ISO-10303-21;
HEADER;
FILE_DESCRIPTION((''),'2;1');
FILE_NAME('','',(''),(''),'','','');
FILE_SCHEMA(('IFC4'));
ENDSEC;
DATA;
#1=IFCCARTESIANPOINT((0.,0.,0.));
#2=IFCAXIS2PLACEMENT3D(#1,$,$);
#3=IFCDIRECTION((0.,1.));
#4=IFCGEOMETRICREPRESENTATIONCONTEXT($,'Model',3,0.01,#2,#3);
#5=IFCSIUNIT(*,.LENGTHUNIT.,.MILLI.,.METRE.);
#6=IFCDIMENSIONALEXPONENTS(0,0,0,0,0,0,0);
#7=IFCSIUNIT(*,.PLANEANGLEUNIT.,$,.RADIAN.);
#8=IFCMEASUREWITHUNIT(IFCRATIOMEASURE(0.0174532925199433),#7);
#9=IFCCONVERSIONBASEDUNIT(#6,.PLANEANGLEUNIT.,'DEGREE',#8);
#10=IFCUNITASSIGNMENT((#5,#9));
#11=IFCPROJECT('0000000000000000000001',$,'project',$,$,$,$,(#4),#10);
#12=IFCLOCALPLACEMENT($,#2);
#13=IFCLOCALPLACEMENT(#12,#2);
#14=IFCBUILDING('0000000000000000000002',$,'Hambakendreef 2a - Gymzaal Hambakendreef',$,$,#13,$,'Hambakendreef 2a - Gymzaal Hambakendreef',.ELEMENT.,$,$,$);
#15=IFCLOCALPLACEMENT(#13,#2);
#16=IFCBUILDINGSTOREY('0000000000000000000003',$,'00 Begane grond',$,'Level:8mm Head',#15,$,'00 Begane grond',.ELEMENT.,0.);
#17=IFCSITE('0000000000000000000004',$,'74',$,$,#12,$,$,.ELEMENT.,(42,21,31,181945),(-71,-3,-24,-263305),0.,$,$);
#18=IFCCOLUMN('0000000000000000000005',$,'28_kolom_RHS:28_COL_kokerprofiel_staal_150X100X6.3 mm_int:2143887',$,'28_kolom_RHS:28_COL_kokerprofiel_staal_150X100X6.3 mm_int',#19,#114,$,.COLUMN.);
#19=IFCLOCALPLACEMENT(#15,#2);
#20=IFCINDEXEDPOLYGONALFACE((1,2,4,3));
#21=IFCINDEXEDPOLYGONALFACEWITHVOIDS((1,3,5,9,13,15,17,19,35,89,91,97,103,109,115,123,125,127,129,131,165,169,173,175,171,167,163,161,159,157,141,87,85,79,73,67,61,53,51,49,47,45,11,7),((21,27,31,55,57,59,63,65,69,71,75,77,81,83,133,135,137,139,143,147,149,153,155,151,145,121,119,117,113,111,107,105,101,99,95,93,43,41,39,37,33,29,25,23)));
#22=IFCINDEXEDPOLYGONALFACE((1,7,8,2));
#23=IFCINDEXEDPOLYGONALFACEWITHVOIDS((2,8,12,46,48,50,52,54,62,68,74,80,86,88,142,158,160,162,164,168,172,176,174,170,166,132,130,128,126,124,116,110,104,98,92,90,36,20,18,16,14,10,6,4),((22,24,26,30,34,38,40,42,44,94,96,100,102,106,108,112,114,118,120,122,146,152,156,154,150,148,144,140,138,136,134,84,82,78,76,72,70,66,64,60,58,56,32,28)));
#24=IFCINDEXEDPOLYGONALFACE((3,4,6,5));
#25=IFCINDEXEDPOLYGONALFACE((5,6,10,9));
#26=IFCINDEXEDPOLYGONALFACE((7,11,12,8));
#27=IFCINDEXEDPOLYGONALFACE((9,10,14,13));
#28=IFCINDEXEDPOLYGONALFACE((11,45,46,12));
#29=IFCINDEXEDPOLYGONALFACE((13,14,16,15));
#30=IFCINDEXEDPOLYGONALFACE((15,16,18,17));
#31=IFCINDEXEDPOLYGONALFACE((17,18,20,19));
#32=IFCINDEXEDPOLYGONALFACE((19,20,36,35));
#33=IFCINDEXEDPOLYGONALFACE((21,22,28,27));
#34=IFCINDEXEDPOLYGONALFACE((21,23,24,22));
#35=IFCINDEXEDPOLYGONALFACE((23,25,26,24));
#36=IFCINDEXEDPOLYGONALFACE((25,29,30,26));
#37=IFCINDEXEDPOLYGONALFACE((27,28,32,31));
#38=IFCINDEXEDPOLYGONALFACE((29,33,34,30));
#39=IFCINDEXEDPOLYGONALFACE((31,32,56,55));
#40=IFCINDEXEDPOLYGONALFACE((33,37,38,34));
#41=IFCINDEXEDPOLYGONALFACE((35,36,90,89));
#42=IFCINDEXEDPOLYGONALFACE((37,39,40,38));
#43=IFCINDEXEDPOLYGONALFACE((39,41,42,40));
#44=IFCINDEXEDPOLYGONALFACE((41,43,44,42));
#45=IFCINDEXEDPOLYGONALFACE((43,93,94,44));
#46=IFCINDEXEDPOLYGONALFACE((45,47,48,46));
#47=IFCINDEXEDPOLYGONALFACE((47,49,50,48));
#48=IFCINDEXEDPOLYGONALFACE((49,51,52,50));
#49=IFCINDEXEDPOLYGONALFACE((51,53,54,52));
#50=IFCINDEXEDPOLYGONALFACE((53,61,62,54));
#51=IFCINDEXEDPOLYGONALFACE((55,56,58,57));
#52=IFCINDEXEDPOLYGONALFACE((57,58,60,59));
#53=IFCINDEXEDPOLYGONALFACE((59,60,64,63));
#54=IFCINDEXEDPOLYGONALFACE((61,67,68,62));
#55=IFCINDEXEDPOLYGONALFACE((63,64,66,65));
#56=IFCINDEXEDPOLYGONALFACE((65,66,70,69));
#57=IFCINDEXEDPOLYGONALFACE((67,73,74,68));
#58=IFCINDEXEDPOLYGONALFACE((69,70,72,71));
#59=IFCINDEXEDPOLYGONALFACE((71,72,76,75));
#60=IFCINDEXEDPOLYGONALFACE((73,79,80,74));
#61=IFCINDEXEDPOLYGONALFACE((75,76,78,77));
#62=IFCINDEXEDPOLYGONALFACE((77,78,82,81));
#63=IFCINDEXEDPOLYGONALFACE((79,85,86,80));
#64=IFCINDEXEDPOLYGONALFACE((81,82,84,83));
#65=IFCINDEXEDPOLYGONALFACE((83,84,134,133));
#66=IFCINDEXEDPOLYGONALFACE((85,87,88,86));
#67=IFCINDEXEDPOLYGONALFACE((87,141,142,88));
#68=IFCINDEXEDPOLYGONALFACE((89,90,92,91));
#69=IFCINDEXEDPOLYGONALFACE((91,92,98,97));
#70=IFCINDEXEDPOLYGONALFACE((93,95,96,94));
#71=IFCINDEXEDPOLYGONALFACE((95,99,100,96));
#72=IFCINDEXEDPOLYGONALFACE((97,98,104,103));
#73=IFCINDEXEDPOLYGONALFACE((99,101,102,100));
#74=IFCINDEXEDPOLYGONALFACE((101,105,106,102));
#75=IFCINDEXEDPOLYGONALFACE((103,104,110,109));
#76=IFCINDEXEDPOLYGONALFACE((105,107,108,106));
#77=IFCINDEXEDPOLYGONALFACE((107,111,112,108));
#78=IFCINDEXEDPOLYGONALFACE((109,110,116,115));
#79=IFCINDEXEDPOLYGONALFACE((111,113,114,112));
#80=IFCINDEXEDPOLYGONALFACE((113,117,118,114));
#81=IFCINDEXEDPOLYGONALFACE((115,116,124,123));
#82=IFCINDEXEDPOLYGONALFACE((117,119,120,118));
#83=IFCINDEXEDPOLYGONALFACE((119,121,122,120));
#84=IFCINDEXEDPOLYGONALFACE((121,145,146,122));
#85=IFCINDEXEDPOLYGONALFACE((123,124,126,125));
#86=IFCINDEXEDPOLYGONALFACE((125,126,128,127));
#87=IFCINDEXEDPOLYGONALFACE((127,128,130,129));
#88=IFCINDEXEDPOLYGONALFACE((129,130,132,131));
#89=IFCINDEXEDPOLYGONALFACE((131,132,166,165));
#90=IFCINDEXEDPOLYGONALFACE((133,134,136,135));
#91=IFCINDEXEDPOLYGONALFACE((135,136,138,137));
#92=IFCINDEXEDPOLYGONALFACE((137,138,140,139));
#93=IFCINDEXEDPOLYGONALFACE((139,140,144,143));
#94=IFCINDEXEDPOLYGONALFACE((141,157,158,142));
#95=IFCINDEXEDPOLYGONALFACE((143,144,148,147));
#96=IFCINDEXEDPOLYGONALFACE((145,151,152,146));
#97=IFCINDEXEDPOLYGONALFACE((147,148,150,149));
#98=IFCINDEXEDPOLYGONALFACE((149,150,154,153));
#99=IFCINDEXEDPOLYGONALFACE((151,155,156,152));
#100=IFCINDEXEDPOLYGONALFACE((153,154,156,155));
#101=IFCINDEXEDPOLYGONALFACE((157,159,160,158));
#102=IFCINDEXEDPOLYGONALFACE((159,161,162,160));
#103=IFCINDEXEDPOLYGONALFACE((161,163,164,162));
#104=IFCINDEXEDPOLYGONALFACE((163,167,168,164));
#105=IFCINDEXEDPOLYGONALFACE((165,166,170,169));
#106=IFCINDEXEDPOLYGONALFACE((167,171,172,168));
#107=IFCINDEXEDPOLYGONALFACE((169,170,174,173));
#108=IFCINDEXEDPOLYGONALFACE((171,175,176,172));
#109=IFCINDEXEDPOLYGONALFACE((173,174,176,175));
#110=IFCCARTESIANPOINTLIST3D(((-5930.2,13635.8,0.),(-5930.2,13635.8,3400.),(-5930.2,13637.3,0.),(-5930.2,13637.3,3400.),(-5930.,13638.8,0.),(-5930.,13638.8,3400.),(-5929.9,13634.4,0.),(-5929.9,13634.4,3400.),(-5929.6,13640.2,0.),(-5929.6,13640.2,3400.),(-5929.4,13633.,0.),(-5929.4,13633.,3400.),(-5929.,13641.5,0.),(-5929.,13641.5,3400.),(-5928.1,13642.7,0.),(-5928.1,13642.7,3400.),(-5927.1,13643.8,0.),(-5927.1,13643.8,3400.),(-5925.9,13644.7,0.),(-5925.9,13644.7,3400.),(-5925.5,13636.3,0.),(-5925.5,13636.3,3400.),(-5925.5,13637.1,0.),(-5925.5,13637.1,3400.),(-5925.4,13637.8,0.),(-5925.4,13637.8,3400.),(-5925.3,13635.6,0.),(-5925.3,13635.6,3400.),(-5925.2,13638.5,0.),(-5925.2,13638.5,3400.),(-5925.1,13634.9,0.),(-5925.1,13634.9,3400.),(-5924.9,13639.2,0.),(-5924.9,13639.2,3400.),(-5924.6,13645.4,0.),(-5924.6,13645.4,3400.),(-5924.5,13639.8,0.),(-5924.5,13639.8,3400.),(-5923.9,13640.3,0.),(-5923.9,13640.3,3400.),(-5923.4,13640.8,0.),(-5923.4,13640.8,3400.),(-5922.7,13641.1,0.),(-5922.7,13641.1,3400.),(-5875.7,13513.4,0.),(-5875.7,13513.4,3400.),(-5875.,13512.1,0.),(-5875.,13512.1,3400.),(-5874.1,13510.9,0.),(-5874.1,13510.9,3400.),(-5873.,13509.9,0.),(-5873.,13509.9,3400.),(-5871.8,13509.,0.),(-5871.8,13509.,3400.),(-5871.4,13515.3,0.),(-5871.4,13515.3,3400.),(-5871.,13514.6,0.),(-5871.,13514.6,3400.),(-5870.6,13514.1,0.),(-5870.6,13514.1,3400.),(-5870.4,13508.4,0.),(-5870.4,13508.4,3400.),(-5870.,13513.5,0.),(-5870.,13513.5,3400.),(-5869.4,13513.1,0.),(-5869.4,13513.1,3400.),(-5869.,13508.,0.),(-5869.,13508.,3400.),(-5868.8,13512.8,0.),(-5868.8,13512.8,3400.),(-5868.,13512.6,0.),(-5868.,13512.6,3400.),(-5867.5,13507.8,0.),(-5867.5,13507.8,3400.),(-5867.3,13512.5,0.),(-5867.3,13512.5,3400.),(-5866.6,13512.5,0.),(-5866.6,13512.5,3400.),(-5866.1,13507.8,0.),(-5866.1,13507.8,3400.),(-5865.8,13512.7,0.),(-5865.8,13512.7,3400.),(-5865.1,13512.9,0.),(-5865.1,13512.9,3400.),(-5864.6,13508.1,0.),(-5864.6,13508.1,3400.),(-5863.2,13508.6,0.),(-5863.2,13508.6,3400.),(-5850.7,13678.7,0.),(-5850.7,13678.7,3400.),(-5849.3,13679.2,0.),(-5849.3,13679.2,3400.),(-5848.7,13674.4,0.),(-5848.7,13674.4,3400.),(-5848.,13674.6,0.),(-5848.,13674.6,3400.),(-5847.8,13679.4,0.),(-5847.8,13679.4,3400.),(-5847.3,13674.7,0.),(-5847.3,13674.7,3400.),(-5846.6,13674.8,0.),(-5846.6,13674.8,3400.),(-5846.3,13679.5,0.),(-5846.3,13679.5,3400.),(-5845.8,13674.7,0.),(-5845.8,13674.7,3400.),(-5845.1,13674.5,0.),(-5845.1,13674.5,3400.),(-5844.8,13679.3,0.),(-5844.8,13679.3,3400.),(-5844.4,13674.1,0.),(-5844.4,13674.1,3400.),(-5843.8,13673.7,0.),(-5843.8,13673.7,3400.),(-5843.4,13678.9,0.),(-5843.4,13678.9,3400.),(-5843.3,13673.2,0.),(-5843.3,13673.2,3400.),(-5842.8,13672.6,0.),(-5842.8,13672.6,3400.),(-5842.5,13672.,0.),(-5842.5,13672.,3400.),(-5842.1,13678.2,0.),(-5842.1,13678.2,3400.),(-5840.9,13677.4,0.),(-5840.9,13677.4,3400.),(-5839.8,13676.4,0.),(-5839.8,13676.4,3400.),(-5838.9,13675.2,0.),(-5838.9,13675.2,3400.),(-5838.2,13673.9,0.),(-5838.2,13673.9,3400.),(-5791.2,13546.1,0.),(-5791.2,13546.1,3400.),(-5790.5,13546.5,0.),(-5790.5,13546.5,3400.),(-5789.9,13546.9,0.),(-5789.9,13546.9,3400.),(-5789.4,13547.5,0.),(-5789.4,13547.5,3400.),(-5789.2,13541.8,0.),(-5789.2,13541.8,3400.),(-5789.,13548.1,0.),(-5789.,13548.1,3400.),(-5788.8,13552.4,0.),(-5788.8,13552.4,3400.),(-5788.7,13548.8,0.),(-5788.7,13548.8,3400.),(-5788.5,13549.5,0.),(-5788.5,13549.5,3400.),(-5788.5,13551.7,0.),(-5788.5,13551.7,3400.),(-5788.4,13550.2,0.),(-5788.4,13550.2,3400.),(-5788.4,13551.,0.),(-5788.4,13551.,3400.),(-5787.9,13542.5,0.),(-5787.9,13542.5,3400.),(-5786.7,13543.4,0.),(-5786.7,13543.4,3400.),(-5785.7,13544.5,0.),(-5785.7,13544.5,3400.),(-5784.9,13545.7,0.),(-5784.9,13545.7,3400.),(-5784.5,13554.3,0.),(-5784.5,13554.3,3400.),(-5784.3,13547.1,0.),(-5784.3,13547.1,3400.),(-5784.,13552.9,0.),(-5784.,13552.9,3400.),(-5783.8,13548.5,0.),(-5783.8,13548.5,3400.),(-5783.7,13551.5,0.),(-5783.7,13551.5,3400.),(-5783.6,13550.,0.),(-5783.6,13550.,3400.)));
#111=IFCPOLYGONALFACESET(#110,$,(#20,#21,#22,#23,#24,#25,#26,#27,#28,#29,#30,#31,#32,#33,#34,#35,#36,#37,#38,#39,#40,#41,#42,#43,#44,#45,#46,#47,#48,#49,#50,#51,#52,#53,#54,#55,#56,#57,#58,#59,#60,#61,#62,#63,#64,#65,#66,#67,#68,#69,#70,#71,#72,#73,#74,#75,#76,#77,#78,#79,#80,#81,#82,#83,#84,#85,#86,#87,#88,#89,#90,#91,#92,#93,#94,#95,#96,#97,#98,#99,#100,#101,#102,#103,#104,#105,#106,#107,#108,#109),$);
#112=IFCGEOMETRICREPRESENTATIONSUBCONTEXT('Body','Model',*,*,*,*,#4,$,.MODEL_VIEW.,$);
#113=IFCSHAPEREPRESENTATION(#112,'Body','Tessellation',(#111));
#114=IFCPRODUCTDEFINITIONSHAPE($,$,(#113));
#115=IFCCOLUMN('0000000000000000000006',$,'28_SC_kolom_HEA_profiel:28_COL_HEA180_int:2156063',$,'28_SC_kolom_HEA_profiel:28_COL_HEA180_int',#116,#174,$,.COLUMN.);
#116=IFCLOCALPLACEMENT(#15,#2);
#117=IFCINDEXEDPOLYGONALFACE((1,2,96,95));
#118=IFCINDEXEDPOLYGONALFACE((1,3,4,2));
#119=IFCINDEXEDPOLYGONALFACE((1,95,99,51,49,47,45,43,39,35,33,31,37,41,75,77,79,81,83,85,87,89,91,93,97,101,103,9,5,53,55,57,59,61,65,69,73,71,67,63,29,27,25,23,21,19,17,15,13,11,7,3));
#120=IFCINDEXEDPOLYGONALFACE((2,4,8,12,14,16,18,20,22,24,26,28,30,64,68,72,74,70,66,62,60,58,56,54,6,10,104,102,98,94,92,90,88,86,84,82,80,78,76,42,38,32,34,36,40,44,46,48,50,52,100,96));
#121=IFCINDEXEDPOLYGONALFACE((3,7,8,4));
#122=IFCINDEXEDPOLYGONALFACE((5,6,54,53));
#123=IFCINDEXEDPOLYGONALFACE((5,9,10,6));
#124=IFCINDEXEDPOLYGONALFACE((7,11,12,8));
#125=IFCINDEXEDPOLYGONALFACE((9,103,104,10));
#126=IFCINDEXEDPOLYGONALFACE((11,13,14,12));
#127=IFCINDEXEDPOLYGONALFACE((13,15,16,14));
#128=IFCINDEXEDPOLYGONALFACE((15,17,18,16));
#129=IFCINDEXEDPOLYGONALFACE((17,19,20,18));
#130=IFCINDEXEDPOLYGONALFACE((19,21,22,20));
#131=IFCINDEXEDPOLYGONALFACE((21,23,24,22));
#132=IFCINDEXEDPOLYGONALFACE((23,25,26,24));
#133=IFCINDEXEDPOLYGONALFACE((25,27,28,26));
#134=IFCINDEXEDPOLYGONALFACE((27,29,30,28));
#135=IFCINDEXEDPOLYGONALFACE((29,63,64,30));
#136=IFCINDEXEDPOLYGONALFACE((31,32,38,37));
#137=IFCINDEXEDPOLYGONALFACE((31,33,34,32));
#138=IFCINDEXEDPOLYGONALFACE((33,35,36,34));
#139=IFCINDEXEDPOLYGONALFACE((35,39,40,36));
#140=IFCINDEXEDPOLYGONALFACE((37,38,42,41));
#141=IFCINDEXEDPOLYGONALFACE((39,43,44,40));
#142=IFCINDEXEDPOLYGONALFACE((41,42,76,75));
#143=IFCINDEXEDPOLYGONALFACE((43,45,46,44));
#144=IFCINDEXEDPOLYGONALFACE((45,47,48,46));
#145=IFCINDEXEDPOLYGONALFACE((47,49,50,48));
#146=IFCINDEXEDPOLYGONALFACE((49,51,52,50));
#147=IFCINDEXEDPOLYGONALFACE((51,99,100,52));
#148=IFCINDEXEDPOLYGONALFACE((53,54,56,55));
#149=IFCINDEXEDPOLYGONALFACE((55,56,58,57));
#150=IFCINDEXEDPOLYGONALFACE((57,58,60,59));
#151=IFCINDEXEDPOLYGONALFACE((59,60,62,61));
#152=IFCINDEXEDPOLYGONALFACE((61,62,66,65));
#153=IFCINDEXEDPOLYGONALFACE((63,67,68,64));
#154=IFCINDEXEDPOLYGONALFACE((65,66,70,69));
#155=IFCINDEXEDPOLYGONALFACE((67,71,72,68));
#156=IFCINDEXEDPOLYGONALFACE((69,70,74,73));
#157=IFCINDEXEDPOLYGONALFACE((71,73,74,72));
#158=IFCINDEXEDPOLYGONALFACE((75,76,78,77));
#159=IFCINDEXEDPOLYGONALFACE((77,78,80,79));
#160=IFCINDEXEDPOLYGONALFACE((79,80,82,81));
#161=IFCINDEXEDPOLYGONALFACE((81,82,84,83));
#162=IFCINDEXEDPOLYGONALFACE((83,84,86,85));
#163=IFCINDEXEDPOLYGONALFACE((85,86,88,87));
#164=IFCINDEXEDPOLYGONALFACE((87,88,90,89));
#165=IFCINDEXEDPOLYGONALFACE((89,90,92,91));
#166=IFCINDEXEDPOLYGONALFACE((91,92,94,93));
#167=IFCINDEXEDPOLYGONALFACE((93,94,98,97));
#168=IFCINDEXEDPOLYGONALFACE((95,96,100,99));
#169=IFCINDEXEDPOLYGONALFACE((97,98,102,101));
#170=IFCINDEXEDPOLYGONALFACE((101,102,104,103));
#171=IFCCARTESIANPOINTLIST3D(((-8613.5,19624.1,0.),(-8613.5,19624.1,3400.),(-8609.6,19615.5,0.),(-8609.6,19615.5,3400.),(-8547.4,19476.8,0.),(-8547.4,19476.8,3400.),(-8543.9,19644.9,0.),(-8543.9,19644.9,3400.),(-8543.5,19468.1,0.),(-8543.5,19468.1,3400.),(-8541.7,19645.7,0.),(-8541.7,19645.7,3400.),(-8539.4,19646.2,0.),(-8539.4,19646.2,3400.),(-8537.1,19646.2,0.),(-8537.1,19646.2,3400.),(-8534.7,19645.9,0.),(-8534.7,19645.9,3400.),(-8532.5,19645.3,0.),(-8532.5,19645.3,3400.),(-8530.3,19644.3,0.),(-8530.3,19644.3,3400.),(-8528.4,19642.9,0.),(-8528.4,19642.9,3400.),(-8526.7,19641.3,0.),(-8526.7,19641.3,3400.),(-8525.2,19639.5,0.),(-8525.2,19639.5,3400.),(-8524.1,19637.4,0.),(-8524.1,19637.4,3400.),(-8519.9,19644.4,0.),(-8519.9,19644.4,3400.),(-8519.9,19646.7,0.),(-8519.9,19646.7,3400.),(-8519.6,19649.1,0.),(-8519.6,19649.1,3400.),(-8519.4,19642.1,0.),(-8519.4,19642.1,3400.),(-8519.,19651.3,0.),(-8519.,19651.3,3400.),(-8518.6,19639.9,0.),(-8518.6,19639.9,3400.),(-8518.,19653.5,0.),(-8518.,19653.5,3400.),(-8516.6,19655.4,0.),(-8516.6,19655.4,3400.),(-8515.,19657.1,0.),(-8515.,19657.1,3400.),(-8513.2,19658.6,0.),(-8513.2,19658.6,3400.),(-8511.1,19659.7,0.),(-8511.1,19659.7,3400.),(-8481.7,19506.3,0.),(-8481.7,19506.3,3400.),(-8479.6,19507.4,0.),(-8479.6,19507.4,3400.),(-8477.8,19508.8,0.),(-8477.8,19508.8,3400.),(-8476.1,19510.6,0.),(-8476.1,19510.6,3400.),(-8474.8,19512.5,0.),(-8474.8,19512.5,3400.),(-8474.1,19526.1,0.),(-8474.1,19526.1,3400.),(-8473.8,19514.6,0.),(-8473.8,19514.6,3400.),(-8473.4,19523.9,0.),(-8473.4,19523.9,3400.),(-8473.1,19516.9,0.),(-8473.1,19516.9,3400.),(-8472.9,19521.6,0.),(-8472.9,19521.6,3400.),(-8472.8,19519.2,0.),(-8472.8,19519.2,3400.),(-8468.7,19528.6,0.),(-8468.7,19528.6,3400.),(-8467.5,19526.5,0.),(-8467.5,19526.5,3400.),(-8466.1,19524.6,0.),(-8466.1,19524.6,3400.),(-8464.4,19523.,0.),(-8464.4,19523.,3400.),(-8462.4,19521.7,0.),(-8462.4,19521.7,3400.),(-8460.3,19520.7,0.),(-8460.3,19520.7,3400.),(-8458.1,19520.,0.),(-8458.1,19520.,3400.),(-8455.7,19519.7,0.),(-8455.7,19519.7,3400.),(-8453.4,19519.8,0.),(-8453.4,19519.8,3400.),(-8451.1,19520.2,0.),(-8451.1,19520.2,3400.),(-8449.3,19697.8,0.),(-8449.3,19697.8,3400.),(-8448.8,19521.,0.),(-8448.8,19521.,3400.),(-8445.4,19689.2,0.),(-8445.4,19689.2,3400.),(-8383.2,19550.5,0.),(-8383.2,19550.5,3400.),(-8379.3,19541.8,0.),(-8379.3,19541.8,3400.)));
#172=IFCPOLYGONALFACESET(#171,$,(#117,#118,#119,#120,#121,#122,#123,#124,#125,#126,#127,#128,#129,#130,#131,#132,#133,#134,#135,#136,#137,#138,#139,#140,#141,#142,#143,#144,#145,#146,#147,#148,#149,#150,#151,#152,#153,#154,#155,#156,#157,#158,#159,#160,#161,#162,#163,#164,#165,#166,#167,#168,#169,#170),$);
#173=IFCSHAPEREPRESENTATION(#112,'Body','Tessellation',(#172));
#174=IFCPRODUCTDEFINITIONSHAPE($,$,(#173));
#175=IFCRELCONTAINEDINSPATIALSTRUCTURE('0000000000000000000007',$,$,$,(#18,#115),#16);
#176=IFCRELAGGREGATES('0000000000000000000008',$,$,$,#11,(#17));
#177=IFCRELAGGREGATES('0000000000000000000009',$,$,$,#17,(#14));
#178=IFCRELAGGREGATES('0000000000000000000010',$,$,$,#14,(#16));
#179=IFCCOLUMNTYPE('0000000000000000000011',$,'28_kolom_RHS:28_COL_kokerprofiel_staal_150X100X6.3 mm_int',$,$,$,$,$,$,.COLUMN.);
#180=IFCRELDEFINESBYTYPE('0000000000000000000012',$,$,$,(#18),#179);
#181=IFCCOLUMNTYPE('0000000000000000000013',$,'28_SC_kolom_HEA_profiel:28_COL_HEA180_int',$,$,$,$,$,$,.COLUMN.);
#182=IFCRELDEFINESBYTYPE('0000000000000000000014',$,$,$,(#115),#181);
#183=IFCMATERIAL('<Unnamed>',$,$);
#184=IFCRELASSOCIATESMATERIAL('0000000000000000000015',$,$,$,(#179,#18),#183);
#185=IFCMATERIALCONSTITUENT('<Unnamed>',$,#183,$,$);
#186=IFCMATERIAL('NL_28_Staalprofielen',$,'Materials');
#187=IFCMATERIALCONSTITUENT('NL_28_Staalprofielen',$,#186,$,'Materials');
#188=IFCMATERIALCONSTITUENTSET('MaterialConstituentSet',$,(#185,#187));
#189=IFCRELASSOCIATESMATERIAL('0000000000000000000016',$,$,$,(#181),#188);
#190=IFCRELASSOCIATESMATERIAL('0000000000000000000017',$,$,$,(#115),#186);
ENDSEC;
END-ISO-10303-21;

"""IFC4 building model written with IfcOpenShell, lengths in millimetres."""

from ifc_helpers import new_model, entity, si_unit, converted_unit, direction, frame, origin, place, context, subcontext, project, spatial, indexed_curve, outline, extrude, source, transform, mapped, material, constituent, constituent_set, type_object, type_shapes, element, save


model = new_model("IFC4")

# Units and contexts
model_context = context("Model", 3, precision=0.01, world=origin(), true_north=direction((0.0, 1.0)))
body_context = subcontext(model_context, "Body", "Model", "MODEL_VIEW")
ifc_project = project(units=[si_unit("LENGTHUNIT", "METRE", prefix="MILLI"), converted_unit("PLANEANGLEUNIT", "DEGREE", entity("IfcRatioMeasure", 0.0174532925199433), si_unit("PLANEANGLEUNIT", "RADIAN"), dimensions=[0, 0, 0, 0, 0, 0, 0])], contexts=[model_context])

# Site, building, storey
site_placement = place(None, origin())
site = spatial("IfcSite", under=ifc_project, at=site_placement, Name="74", CompositionType="ELEMENT", RefLatitude=(42, 21, 31, 181945), RefLongitude=(-71, -3, -24, -263305), RefElevation=0.0)
building_placement = place(site_placement, origin())
building = spatial("IfcBuilding", under=site, at=building_placement, Name="Hambakendreef 2a - Gymzaal Hambakendreef", LongName="Hambakendreef 2a - Gymzaal Hambakendreef", CompositionType="ELEMENT")
storey_placement = place(building_placement, origin())
storey = spatial("IfcBuildingStorey", under=building, at=storey_placement, Name="00 Begane grond", ObjectType="Level:8mm Head", LongName="00 Begane grond", CompositionType="ELEMENT", Elevation=0.0)

# Columns
ifc_material_1 = material(Name="NL_28_Staalprofielen", Category="Materials")
ifc_material_2 = material(Name="<Unnamed>")
column_type_1 = type_object("IfcColumnType", Name="28_kolom_RHS:28_COL_kokerprofiel_staal_150X100X6.3 mm_int", PredefinedType="COLUMN", material=ifc_material_2)
shared_shape_1 = source(origin(), body_context, "Body", "SweptSolid", [
    extrude(outline(indexed_curve([(-40.5, -75.0), (40.5, -75.0), (42.0, -74.9), (43.5, -74.5), (44.8, -74.0), (46.1, -73.2), (47.2, -72.2), (48.2, -71.1), (49.0, -69.8), (49.5, -68.5), (49.9, -67.0), (50.0, -65.6), (50.0, 65.6), (49.9, 67.0), (49.5, 68.5), (49.0, 69.8), (48.2, 71.1), (47.2, 72.2), (46.1, 73.2), (44.8, 74.0), (43.5, 74.5), (42.0, 74.9), (40.5, 75.0), (-40.5, 75.0), (-42.0, 74.9), (-43.5, 74.5), (-44.8, 74.0), (-46.1, 73.2), (-47.2, 72.2), (-48.2, 71.1), (-49.0, 69.8), (-49.5, 68.5), (-49.9, 67.0), (-50.0, 65.6), (-50.0, -65.6), (-49.9, -67.0), (-49.5, -68.5), (-49.0, -69.8), (-48.2, -71.1), (-47.2, -72.2), (-46.1, -73.2), (-44.8, -74.0), (-43.5, -74.5), (-42.0, -74.9), (-40.5, -75.0)], self_intersect=False), holes=[indexed_curve([(-45.3, 65.5), (-45.2, 66.3), (-45.0, 67.0), (-44.8, 67.7), (-44.4, 68.3), (-43.9, 68.9), (-43.3, 69.4), (-42.7, 69.8), (-42.0, 70.0), (-41.3, 70.2), (-40.6, 70.3), (40.5, 70.3), (41.3, 70.2), (42.0, 70.0), (42.7, 69.8), (43.3, 69.4), (43.9, 68.9), (44.4, 68.3), (44.8, 67.7), (45.0, 67.0), (45.2, 66.3), (45.3, 65.5), (45.3, -65.5), (45.2, -66.3), (45.0, -67.0), (44.8, -67.7), (44.4, -68.3), (43.9, -68.9), (43.3, -69.4), (42.7, -69.8), (42.0, -70.0), (41.3, -70.2), (40.5, -70.3), (-40.6, -70.3), (-41.3, -70.2), (-42.0, -70.0), (-42.7, -69.8), (-43.3, -69.4), (-43.9, -68.9), (-44.4, -68.3), (-44.8, -67.7), (-45.0, -67.0), (-45.2, -66.3), (-45.3, -65.5), (-45.3, 65.5)], self_intersect=False)]), frame((235.6, 34.3, 0.0), z_axis=(0.0, 0.0, 1.0), x_axis=(0.0, 1.0, 0.0)), (0.0, 0.0, 1.0), 3400.0),
])
type_shapes(column_type_1, [shared_shape_1])
for number, where, z_axis, x_axis, name in (
    (1, (-5984.7, 13794.5, 0.0), (0.0, 0.0, 1.0), (0.40959, -0.91227, 0.0), "28_kolom_RHS:28_COL_kokerprofiel_staal_150X100X6.3 mm_int:2143887"),
):
    element("IfcColumn", number, at=place(storey_placement, frame(where, z_axis=z_axis, x_axis=x_axis)), inside=storey, type_object=column_type_1, material=ifc_material_2, Name=name, ObjectType="28_kolom_RHS:28_COL_kokerprofiel_staal_150X100X6.3 mm_int", PredefinedType="COLUMN", context=body_context, shape_type="MappedRepresentation", body=[
        mapped(shared_shape_1, transform((0.0, 0.0, 0.0), scale=1.0)),
    ])
ifc_constituent_1 = constituent(ifc_material_2, Name="<Unnamed>")
ifc_constituent_2 = constituent(ifc_material_1, Name="NL_28_Staalprofielen", Category="Materials")
ifc_constituent_set_1 = constituent_set(constituents=[ifc_constituent_1, ifc_constituent_2], Name="MaterialConstituentSet")
column_type_2 = type_object("IfcColumnType", Name="28_SC_kolom_HEA_profiel:28_COL_HEA180_int", PredefinedType="COLUMN", material=ifc_constituent_set_1)
shared_shape_2 = source(origin(), body_context, "Body", "SweptSolid", [
    extrude(outline(indexed_curve([(-85.5, -90.0), (-76.0, -90.0), (-76.0, -18.0), (-75.8, -15.7), (-75.3, -13.4), (-74.4, -11.2), (-73.1, -9.2), (-71.6, -7.4), (-69.8, -5.9), (-67.8, -4.6), (-65.6, -3.7), (-63.3, -3.2), (-61.0, -3.0), (61.0, -3.0), (63.3, -3.2), (65.6, -3.7), (67.8, -4.6), (69.8, -5.9), (71.6, -7.4), (73.1, -9.2), (74.4, -11.2), (75.3, -13.4), (75.8, -15.7), (76.0, -18.0), (76.0, -90.0), (85.5, -90.0), (85.5, 90.0), (76.0, 90.0), (76.0, 18.0), (75.8, 15.7), (75.3, 13.4), (74.4, 11.2), (73.1, 9.2), (71.6, 7.4), (69.8, 5.9), (67.8, 4.6), (65.6, 3.7), (63.3, 3.2), (61.0, 3.0), (-61.0, 3.0), (-63.3, 3.2), (-65.6, 3.7), (-67.8, 4.6), (-69.8, 5.9), (-71.6, 7.4), (-73.1, 9.2), (-74.4, 11.2), (-75.3, 13.4), (-75.8, 15.7), (-76.0, 18.0), (-76.0, 90.0), (-85.5, 90.0), (-85.5, -90.0)], self_intersect=False)), frame((0.0, 0.0, 0.0), z_axis=(0.0, 0.0, 1.0), x_axis=(0.0, -1.0, 0.0)), (0.0, 0.0, 1.0), 3400.0),
])
type_shapes(column_type_2, [shared_shape_2])
for number, where, z_axis, x_axis, name in (
    (2, (-8496.4, 19583.0, 0.0), (0.0, 0.0, 1.0), (0.91227, 0.40959, 0.0), "28_SC_kolom_HEA_profiel:28_COL_HEA180_int:2156063"),
):
    element("IfcColumn", number, at=place(storey_placement, frame(where, z_axis=z_axis, x_axis=x_axis)), inside=storey, type_object=column_type_2, material=ifc_material_1, Name=name, ObjectType="28_SC_kolom_HEA_profiel:28_COL_HEA180_int", PredefinedType="COLUMN", context=body_context, shape_type="MappedRepresentation", body=[
        mapped(shared_shape_2, transform((0.0, 0.0, 0.0), scale=1.0)),
    ])

save(model, "model.ifc")
